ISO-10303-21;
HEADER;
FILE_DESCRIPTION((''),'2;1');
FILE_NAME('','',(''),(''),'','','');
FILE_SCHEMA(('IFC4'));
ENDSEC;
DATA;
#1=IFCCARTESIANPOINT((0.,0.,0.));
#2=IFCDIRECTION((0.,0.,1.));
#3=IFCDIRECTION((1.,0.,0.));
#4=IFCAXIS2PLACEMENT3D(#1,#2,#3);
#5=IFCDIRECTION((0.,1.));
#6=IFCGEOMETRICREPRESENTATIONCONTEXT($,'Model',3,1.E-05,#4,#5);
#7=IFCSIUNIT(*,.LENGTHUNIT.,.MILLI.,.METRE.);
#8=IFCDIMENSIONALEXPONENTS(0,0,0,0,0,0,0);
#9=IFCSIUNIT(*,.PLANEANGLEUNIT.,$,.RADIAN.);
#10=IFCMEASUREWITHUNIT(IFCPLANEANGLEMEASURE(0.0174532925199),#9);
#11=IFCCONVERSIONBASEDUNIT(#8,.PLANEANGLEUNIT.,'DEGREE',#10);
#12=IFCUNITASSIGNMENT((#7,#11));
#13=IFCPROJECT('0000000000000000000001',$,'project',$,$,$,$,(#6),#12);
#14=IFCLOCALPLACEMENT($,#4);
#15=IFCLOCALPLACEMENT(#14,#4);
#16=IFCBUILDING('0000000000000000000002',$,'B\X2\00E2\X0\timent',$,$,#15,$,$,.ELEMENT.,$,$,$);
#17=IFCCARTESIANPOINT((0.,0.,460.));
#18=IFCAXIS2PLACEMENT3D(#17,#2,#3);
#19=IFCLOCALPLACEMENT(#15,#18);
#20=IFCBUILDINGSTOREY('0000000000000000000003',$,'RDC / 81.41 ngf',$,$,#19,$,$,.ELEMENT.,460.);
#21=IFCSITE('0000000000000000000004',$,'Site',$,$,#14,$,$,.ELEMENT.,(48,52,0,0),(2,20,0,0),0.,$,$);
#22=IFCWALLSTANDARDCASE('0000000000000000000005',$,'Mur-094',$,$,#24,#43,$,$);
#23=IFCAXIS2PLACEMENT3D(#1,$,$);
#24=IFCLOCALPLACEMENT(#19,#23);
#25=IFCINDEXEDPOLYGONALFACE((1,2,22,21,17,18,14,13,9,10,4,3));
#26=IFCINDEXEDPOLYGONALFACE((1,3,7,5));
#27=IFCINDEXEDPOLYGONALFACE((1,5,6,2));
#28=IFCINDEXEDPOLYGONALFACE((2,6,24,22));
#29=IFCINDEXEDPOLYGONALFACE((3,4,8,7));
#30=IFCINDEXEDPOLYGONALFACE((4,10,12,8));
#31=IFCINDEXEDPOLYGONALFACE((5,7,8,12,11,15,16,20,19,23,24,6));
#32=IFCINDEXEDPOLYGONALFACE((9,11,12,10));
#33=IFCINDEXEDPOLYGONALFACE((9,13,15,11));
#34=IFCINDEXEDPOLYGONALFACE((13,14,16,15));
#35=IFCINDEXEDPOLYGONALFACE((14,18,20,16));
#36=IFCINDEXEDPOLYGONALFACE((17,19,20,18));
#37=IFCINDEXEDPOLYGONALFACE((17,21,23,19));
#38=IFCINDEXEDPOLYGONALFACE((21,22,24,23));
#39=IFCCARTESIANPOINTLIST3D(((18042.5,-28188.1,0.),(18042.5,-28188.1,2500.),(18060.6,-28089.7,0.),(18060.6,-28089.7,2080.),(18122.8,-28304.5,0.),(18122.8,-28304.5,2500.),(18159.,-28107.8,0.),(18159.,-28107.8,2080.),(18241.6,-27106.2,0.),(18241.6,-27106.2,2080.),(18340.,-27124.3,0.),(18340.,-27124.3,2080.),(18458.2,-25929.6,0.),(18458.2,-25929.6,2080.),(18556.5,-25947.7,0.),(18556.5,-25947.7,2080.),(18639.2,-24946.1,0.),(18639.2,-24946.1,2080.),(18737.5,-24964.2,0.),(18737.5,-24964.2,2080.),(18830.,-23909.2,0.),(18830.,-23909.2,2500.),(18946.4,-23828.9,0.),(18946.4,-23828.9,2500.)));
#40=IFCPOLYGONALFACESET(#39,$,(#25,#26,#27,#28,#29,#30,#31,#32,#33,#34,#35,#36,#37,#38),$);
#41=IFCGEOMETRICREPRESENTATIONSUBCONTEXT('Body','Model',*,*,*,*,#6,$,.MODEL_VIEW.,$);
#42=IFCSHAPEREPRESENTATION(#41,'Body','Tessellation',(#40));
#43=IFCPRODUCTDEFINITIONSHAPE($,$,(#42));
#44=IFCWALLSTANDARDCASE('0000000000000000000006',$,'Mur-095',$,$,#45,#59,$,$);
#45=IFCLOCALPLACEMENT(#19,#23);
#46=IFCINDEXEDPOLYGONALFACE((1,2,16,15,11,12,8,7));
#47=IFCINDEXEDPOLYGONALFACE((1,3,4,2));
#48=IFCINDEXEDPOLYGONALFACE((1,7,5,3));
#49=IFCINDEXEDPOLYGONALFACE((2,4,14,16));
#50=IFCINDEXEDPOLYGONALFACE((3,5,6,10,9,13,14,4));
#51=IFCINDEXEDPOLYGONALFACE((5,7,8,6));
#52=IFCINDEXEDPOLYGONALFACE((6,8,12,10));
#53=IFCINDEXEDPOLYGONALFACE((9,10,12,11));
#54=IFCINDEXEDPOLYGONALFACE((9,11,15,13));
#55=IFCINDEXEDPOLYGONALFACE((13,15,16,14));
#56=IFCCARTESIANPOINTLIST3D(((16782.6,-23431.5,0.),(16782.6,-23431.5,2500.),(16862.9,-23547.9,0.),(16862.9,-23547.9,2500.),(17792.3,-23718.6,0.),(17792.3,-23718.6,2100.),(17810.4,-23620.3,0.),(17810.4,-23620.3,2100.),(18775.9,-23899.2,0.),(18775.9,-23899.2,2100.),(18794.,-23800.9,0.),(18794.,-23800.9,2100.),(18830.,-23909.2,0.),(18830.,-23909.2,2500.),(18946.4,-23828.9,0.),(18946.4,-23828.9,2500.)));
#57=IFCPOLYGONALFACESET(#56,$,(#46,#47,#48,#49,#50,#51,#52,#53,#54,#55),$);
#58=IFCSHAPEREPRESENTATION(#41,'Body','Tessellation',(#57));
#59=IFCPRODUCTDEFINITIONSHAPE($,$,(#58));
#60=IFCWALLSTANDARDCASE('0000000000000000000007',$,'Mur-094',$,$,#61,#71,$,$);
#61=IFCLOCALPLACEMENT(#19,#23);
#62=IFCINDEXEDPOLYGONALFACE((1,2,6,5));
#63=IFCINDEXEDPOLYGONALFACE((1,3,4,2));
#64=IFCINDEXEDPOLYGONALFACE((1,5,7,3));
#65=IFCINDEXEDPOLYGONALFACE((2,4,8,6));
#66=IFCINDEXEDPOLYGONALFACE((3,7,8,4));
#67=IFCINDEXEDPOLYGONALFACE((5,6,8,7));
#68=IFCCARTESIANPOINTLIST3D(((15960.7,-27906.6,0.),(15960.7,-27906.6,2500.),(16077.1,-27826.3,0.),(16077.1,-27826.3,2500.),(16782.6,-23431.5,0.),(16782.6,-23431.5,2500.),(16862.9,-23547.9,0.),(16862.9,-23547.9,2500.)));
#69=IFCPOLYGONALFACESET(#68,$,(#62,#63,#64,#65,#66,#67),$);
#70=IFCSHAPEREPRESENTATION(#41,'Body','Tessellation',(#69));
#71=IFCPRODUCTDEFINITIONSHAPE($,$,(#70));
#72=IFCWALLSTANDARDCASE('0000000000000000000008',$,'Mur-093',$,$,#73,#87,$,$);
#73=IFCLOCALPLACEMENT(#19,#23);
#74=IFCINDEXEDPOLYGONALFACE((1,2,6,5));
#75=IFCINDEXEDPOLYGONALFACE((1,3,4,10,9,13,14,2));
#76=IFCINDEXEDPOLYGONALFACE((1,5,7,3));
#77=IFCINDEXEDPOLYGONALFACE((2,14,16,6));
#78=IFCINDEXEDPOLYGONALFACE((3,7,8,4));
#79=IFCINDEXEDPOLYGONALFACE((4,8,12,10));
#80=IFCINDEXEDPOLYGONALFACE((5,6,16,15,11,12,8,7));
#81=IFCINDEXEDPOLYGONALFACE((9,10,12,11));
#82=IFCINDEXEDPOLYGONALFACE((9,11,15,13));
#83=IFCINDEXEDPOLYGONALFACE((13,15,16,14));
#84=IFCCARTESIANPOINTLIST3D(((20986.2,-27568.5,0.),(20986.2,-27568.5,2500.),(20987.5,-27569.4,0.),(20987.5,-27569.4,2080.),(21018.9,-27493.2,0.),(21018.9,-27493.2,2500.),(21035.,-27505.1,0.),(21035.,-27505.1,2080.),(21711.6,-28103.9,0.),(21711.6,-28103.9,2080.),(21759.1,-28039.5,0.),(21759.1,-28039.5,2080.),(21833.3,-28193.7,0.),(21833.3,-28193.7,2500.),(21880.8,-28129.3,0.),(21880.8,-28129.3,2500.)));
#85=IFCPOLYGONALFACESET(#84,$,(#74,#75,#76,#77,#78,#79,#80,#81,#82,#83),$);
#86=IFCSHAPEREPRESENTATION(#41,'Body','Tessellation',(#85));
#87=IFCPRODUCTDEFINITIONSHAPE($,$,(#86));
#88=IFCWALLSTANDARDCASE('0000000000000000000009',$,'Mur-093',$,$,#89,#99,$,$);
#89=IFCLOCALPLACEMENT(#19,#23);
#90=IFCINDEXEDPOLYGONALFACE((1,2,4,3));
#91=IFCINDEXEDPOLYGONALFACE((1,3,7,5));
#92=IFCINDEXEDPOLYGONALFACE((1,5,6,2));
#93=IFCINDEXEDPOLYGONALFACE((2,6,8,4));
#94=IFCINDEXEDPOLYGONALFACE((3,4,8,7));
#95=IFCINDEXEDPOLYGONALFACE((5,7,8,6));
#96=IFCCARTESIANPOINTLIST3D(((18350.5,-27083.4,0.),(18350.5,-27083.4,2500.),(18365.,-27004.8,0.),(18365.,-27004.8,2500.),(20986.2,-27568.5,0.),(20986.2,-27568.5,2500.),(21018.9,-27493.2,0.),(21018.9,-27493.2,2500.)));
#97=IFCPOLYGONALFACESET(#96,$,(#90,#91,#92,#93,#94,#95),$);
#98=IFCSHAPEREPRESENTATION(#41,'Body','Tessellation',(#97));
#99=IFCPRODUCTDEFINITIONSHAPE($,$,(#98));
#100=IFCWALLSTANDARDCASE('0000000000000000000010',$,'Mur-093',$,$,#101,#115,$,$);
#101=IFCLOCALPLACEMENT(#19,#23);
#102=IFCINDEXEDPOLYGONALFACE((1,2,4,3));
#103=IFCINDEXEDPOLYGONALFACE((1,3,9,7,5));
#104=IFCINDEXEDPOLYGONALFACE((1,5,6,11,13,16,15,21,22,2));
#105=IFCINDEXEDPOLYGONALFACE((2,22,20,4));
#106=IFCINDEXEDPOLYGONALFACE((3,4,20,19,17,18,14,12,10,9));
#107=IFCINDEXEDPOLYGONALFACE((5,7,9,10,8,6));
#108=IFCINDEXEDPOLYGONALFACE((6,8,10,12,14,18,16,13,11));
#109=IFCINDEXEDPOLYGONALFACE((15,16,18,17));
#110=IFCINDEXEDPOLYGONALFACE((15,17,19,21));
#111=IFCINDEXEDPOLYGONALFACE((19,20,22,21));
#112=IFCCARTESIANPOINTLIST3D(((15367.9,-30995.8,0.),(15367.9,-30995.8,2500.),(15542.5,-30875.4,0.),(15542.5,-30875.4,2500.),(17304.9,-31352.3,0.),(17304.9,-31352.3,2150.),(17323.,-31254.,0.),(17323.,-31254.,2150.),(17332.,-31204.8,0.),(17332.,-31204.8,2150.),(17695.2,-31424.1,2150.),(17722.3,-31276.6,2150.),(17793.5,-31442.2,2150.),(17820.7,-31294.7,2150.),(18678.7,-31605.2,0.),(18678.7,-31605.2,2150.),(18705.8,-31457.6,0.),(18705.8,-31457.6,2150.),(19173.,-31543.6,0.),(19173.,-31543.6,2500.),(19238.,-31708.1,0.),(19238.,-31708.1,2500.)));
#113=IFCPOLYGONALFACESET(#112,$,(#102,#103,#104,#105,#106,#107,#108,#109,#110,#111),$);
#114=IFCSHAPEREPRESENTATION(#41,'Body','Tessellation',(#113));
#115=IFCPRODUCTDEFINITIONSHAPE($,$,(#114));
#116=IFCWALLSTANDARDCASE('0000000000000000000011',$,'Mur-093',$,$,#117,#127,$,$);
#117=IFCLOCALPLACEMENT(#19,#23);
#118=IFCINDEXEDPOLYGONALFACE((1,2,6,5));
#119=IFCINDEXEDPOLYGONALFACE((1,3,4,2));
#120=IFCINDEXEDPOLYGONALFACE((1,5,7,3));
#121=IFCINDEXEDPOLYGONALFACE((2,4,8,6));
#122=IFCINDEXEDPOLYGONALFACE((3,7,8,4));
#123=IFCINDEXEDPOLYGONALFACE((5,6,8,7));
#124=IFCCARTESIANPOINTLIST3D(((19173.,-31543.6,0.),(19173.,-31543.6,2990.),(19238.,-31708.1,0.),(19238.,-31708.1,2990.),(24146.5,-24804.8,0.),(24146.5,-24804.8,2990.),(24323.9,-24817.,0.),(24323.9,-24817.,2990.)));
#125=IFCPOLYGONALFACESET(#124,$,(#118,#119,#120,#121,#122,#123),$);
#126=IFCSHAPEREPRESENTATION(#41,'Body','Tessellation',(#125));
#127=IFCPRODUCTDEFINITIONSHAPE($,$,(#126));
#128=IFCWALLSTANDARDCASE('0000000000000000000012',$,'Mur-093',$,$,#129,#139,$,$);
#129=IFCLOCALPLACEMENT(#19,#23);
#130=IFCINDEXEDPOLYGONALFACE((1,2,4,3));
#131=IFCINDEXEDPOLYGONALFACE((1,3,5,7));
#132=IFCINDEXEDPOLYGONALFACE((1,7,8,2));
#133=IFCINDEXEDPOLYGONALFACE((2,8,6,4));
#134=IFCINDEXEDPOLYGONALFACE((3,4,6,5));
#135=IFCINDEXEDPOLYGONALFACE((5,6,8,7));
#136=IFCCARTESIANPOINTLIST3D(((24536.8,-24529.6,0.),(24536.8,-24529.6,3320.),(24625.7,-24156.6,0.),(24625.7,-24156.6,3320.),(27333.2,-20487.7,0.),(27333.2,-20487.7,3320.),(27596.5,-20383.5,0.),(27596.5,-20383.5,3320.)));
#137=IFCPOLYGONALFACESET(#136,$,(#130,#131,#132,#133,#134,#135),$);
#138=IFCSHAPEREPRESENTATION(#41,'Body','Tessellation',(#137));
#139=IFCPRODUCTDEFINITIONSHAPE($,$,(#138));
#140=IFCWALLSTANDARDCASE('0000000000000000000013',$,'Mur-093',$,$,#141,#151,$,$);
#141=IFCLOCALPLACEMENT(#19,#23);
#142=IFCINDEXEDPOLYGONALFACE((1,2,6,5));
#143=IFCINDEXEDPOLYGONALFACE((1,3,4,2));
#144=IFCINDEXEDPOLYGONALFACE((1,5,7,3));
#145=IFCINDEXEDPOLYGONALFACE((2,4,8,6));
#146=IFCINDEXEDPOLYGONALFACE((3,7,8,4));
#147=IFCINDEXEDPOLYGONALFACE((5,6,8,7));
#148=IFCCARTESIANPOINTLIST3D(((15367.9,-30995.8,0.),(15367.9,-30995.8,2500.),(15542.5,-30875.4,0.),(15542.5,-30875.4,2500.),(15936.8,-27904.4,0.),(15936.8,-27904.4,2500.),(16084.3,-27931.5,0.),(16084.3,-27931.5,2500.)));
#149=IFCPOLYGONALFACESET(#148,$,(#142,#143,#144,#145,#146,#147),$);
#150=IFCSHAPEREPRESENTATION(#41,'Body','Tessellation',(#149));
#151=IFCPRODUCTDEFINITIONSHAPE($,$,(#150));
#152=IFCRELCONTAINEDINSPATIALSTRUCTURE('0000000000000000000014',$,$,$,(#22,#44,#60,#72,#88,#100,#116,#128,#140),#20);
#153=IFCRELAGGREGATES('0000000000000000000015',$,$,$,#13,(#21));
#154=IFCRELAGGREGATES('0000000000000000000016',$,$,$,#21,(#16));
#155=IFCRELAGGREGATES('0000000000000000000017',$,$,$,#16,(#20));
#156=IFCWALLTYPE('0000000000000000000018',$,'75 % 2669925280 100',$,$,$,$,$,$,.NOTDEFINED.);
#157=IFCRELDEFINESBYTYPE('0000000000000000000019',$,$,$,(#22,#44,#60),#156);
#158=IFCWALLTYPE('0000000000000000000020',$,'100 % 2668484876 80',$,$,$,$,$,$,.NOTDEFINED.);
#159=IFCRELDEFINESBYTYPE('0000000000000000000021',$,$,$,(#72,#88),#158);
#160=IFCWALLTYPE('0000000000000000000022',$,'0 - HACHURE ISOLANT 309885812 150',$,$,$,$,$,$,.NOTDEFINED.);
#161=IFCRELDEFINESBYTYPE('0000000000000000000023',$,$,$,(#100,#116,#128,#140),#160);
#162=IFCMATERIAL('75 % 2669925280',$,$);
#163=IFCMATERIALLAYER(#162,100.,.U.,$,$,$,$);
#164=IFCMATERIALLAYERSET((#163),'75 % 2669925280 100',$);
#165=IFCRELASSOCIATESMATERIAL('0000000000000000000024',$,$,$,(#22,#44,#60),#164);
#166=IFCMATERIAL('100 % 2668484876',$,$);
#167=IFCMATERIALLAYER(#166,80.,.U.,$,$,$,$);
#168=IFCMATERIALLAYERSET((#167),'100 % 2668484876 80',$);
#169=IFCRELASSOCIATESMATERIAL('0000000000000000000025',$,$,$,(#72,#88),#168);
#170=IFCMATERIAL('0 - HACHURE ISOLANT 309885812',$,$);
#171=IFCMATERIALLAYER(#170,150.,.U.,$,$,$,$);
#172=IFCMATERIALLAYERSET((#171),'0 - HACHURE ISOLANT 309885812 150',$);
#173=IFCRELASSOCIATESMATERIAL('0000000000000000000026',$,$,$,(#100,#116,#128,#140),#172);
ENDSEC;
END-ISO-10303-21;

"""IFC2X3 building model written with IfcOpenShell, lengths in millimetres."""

from ifc_helpers import new_model, entity, si_unit, converted_unit, direction, frame, origin_with_axes, origin_2d_with_axis, place, context, subcontext, project, spatial, polyline, rectangle, outline, extrude, material, layer, layer_set, layer_usage, type_object, element, save


model = new_model("IFC2X3")

# Units and contexts
model_context = context("Model", 3, precision=1e-05, world=origin_with_axes(), true_north=direction((0.0, 1.0)))
body_context = subcontext(model_context, "Body", "Model", "MODEL_VIEW")
ifc_project = project(units=[si_unit("LENGTHUNIT", "METRE", prefix="MILLI"), converted_unit("PLANEANGLEUNIT", "DEGREE", entity("IfcPlaneAngleMeasure", 0.0174532925199), si_unit("PLANEANGLEUNIT", "RADIAN"), dimensions=[0, 0, 0, 0, 0, 0, 0])], contexts=[model_context])

# Site, building, storey
site_placement = place(None, origin_with_axes())
site = spatial("IfcSite", under=ifc_project, at=site_placement, Name="Site", CompositionType="ELEMENT", RefLatitude=(48, 52, 0, 0), RefLongitude=(2, 20, 0, 0), RefElevation=0.0)
building_placement = place(site_placement, origin_with_axes())
building = spatial("IfcBuilding", under=site, at=building_placement, Name="Bâtiment", CompositionType="ELEMENT")
storey_placement = place(building_placement, frame((0.0, 0.0, 460.0), z_axis=(0.0, 0.0, 1.0), x_axis=(1.0, 0.0, 0.0)))
storey = spatial("IfcBuildingStorey", under=building, at=storey_placement, Name="RDC / 81.41 ngf", CompositionType="ELEMENT", Elevation=460.0)

# Shared definitions
ifc_material_1 = material(Name="100 % 2668484876")

# Shared definitions
ifc_material_2 = material(Name="75 % 2669925280")
ifc_layer_1 = layer(ifc_material_2, 100.0, ventilated="UNKNOWN")
ifc_layer_set_1 = layer_set([ifc_layer_1], Name="75 % 2669925280 100")
wall_type_1 = type_object("IfcWallType", Name="75 % 2669925280 100", PredefinedType="NOTDEFINED")

# Wall, openings
ifc_layer_usage_1 = layer_usage(ifc_layer_set_1, "AXIS2", "POSITIVE", -100.0)
wall_1_placement = place(storey_placement, frame((18042.5, -28188.1, 0.0), z_axis=(0.0, 0.0, 1.0), x_axis=(0.180998, 0.983484, 0.0)))
wall_1 = element("IfcWallStandardCase", 1, at=wall_1_placement, inside=storey, type_object=wall_type_1, material=ifc_layer_usage_1, Name="Mur-094", context=body_context, shape_type="SweptSolid", body=[
    extrude(outline(polyline([(-100.0, -100.0), (4450.8, -100.0), (4350.7, 0.0), (0.0, 0.0), (-100.0, -100.0)])), origin_with_axes(), (0.0, 0.0, 1.0), 2500.0),
])
opening_1_placement = place(wall_1_placement, frame((2796.4, 0.0, 0.0), z_axis=(0.0, 0.0, 1.0), x_axis=(1.0, 0.0, 0.0)))
element("IfcOpeningElement", 2, at=opening_1_placement, cuts=wall_1, context=body_context, shape_type="SweptSolid", body=[
    extrude(rectangle(XDim=1000.0, YDim=2080.0, at=origin_2d_with_axis()), frame((0.0, 100.0, 1040.0), z_axis=(0.0, -1.0, 0.0), x_axis=(1.0, 0.0, 0.0)), (0.0, 0.0, 1.0), 300.0),
])
opening_2_placement = place(wall_1_placement, frame((600.0, 0.0, 0.0), z_axis=(0.0, 0.0, 1.0), x_axis=(1.0, 0.0, 0.0)))
element("IfcOpeningElement", 3, at=opening_2_placement, cuts=wall_1, context=body_context, shape_type="SweptSolid", body=[
    extrude(rectangle(XDim=1000.0, YDim=2080.0, at=origin_2d_with_axis()), frame((0.0, 100.0, 1040.0), z_axis=(0.0, -1.0, 0.0), x_axis=(1.0, 0.0, 0.0)), (0.0, 0.0, 1.0), 300.0),
])

# Wall, opening
ifc_layer_usage_2 = layer_usage(ifc_layer_set_1, "AXIS2", "NEGATIVE", 100.0)
wall_2_placement = place(storey_placement, frame((16862.9, -23547.9, 0.0), z_axis=(0.0, 0.0, 1.0), x_axis=(0.98355, -0.180636, 0.0)))
wall_2 = element("IfcWallStandardCase", 4, at=wall_2_placement, inside=storey, type_object=wall_type_1, material=ifc_layer_usage_2, Name="Mur-095", context=body_context, shape_type="SweptSolid", body=[
    extrude(outline(polyline([(0.0, 0.0), (2000.0, 0.0), (2100.0, 100.0), (-100.0, 100.0), (0.0, 0.0)])), origin_with_axes(), (0.0, 0.0, 1.0), 2500.0),
])
opening_3_placement = place(wall_2_placement, frame((1445.0, 0.0, 0.0), z_axis=(0.0, 0.0, 1.0), x_axis=(1.0, 0.0, 0.0)))
element("IfcOpeningElement", 5, at=opening_3_placement, cuts=wall_2, context=body_context, shape_type="SweptSolid", body=[
    extrude(rectangle(XDim=1000.0, YDim=2100.0, at=origin_2d_with_axis()), frame((0.0, 200.0, 1050.0), z_axis=(0.0, 1.0, 0.0), x_axis=(-1.0, 0.0, 0.0)), (0.0, 0.0, -1.0), 300.0),
])

# Wall
ifc_layer_usage_3 = layer_usage(ifc_layer_set_1, "AXIS2", "NEGATIVE", 100.0)
wall_3_placement = place(storey_placement, frame((16077.1, -27826.3, 0.0), z_axis=(0.0, 0.0, 1.0), x_axis=(0.180636, 0.98355, 0.0)))
element("IfcWallStandardCase", 6, at=wall_3_placement, inside=storey, type_object=wall_type_1, material=ifc_layer_usage_3, Name="Mur-094", context=body_context, shape_type="SweptSolid", body=[
    extrude(outline(polyline([(0.0, 0.0), (4350.0, 0.0), (4450.0, 100.0), (-100.0, 100.0), (0.0, 0.0)])), origin_with_axes(), (0.0, 0.0, 1.0), 2500.0),
])

# Wall, opening
ifc_layer_2 = layer(ifc_material_1, 80.0, ventilated="UNKNOWN")
ifc_layer_set_2 = layer_set([ifc_layer_2], Name="100 % 2668484876 80")
ifc_layer_usage_4 = layer_usage(ifc_layer_set_2, "AXIS2", "NEGATIVE", 80.0)
wall_type_2 = type_object("IfcWallType", Name="100 % 2668484876 80", PredefinedType="NOTDEFINED")
wall_4_placement = place(storey_placement, frame((20986.2, -27568.5, 0.0), z_axis=(0.0, 0.0, 1.0), x_axis=(0.804597, -0.593821, 0.0)))
wall_4 = element("IfcWallStandardCase", 7, at=wall_4_placement, inside=storey, type_object=wall_type_2, material=ifc_layer_usage_4, Name="Mur-093", context=body_context, shape_type="SweptSolid", body=[
    extrude(outline(polyline([(0.0, 0.0), (1052.8, 0.0), (1052.8, 80.0), (-18.5, 80.0), (0.0, 0.0)])), origin_with_axes(), (0.0, 0.0, 1.0), 2500.0),
])
opening_4_placement = place(wall_4_placement, frame((451.6, 0.0, 0.0), z_axis=(0.0, 0.0, 1.0), x_axis=(1.0, 0.0, 0.0)))
element("IfcOpeningElement", 8, at=opening_4_placement, cuts=wall_4, context=body_context, shape_type="SweptSolid", body=[
    extrude(rectangle(XDim=900.0, YDim=2080.0, at=origin_2d_with_axis()), frame((0.0, 160.0, 1040.0), z_axis=(0.0, -1.0, 0.0), x_axis=(1.0, 0.0, 0.0)), (0.0, 0.0, 1.0), 240.0),
])

# Wall
ifc_layer_usage_5 = layer_usage(ifc_layer_set_2, "AXIS2", "NEGATIVE", 80.0)
wall_5_placement = place(storey_placement, frame((18350.5, -27083.4, 0.0), z_axis=(0.0, 0.0, 1.0), x_axis=(0.983484, -0.180998, 0.0)))
element("IfcWallStandardCase", 9, at=wall_5_placement, inside=storey, type_object=wall_type_2, material=ifc_layer_usage_5, Name="Mur-093", context=body_context, shape_type="SweptSolid", body=[
    extrude(outline(polyline([(0.0, 0.0), (2680.0, 0.0), (2698.5, 80.0), (0.0, 80.0), (0.0, 0.0)])), origin_with_axes(), (0.0, 0.0, 1.0), 2500.0),
])

# Wall, openings
ifc_material_3 = material(Name="0 - HACHURE ISOLANT 309885812")
ifc_layer_3 = layer(ifc_material_3, 150.0, ventilated="UNKNOWN")
ifc_layer_set_3 = layer_set([ifc_layer_3], Name="0 - HACHURE ISOLANT 309885812 150")
ifc_layer_usage_6 = layer_usage(ifc_layer_set_3, "AXIS2", "POSITIVE", -150.0)
wall_type_3 = type_object("IfcWallType", Name="0 - HACHURE ISOLANT 309885812 150", PredefinedType="NOTDEFINED")
wall_6_placement = place(storey_placement, frame((15542.5, -30875.4, 0.0), z_axis=(0.0, 0.0, 1.0), x_axis=(0.983479, -0.181024, 0.0)))
wall_6 = element("IfcWallStandardCase", 10, at=wall_6_placement, inside=storey, type_object=wall_type_3, material=ifc_layer_usage_6, Name="Mur-093", context=body_context, shape_type="SweptSolid", body=[
    extrude(outline(polyline([(-150.0, -150.0), (3785.2, -150.0), (3691.4, 0.0), (0.0, 0.0), (-150.0, -150.0)])), origin_with_axes(), (0.0, 0.0, 1.0), 2500.0),
])
opening_5_placement = place(wall_6_placement, frame((2068.0, 0.0, 0.0), z_axis=(0.0, 0.0, 1.0), x_axis=(1.0, 0.0, 0.0)))
element("IfcOpeningElement", 11, at=opening_5_placement, cuts=wall_6, context=body_context, shape_type="SweptSolid", body=[
    extrude(rectangle(XDim=496.8, YDim=2150.0, at=origin_2d_with_axis()), frame((0.0, -300.0, 1075.0), z_axis=(0.0, 1.0, 0.0), x_axis=(1.0, 0.0, 0.0)), (0.0, 0.0, 1.0), 250.0),
    extrude(rectangle(XDim=496.8, YDim=2150.0, at=origin_2d_with_axis()), frame((0.0, 150.0, 1075.0), z_axis=(0.0, -1.0, 0.0), x_axis=(1.0, 0.0, 0.0)), (0.0, 0.0, 1.0), 200.0),
])
opening_6_placement = place(wall_6_placement, frame((2716.4, 0.0, 0.0), z_axis=(0.0, 0.0, 1.0), x_axis=(1.0, 0.0, 0.0)))
element("IfcOpeningElement", 12, at=opening_6_placement, cuts=wall_6, context=body_context, shape_type="SweptSolid", body=[
    extrude(rectangle(XDim=1000.0, YDim=2150.0, at=origin_2d_with_axis()), frame((0.0, -300.0, 1075.0), z_axis=(0.0, 1.0, 0.0), x_axis=(1.0, 0.0, 0.0)), (0.0, 0.0, 1.0), 450.0),
])

# Walls
ifc_layer_usage_7 = layer_usage(ifc_layer_set_3, "AXIS2", "POSITIVE", -150.0)
wall_7_placement = place(storey_placement, frame((19173.0, -31543.6, 0.0), z_axis=(0.0, 0.0, 1.0), x_axis=(0.593821, 0.804597, 0.0)))
element("IfcWallStandardCase", 13, at=wall_7_placement, inside=storey, type_object=wall_type_3, material=ifc_layer_usage_7, Name="Mur-093", context=body_context, shape_type="SweptSolid", body=[
    extrude(outline(polyline([(-93.7, -150.0), (8470.9, -150.0), (8375.5, 0.0), (0.0, 0.0), (-93.7, -150.0)])), origin_with_axes(), (0.0, 0.0, 1.0), 2990.0),
])
ifc_layer_usage_8 = layer_usage(ifc_layer_set_3, "AXIS2", "POSITIVE", -150.0)
wall_8_placement = place(storey_placement, frame((24625.7, -24156.6, 0.0), z_axis=(0.0, 0.0, 1.0), x_axis=(0.593784, 0.804624, 0.0)))
element("IfcWallStandardCase", 14, at=wall_8_placement, inside=storey, type_object=wall_type_3, material=ifc_layer_usage_8, Name="Mur-093", context=body_context, shape_type="SweptSolid", body=[
    extrude(outline(polyline([(-353.0, -150.0), (4799.9, -150.0), (4559.8, 0.0), (0.0, 0.0), (-353.0, -150.0)])), origin_with_axes(), (0.0, 0.0, 1.0), 3320.0),
])
ifc_layer_usage_9 = layer_usage(ifc_layer_set_3, "AXIS2", "POSITIVE", -150.0)
wall_9_placement = place(storey_placement, frame((16084.3, -27931.5, 0.0), z_axis=(0.0, 0.0, 1.0), x_axis=(-0.180998, -0.983484, 0.0)))
element("IfcWallStandardCase", 15, at=wall_9_placement, inside=storey, type_object=wall_type_3, material=ifc_layer_usage_9, Name="Mur-093", context=body_context, shape_type="SweptSolid", body=[
    extrude(outline(polyline([(0.0, -150.0), (3143.3, -150.0), (2993.3, 0.0), (0.0, 0.0), (0.0, -150.0)])), origin_with_axes(), (0.0, 0.0, 1.0), 2500.0),
])

save(model, "model.ifc")
